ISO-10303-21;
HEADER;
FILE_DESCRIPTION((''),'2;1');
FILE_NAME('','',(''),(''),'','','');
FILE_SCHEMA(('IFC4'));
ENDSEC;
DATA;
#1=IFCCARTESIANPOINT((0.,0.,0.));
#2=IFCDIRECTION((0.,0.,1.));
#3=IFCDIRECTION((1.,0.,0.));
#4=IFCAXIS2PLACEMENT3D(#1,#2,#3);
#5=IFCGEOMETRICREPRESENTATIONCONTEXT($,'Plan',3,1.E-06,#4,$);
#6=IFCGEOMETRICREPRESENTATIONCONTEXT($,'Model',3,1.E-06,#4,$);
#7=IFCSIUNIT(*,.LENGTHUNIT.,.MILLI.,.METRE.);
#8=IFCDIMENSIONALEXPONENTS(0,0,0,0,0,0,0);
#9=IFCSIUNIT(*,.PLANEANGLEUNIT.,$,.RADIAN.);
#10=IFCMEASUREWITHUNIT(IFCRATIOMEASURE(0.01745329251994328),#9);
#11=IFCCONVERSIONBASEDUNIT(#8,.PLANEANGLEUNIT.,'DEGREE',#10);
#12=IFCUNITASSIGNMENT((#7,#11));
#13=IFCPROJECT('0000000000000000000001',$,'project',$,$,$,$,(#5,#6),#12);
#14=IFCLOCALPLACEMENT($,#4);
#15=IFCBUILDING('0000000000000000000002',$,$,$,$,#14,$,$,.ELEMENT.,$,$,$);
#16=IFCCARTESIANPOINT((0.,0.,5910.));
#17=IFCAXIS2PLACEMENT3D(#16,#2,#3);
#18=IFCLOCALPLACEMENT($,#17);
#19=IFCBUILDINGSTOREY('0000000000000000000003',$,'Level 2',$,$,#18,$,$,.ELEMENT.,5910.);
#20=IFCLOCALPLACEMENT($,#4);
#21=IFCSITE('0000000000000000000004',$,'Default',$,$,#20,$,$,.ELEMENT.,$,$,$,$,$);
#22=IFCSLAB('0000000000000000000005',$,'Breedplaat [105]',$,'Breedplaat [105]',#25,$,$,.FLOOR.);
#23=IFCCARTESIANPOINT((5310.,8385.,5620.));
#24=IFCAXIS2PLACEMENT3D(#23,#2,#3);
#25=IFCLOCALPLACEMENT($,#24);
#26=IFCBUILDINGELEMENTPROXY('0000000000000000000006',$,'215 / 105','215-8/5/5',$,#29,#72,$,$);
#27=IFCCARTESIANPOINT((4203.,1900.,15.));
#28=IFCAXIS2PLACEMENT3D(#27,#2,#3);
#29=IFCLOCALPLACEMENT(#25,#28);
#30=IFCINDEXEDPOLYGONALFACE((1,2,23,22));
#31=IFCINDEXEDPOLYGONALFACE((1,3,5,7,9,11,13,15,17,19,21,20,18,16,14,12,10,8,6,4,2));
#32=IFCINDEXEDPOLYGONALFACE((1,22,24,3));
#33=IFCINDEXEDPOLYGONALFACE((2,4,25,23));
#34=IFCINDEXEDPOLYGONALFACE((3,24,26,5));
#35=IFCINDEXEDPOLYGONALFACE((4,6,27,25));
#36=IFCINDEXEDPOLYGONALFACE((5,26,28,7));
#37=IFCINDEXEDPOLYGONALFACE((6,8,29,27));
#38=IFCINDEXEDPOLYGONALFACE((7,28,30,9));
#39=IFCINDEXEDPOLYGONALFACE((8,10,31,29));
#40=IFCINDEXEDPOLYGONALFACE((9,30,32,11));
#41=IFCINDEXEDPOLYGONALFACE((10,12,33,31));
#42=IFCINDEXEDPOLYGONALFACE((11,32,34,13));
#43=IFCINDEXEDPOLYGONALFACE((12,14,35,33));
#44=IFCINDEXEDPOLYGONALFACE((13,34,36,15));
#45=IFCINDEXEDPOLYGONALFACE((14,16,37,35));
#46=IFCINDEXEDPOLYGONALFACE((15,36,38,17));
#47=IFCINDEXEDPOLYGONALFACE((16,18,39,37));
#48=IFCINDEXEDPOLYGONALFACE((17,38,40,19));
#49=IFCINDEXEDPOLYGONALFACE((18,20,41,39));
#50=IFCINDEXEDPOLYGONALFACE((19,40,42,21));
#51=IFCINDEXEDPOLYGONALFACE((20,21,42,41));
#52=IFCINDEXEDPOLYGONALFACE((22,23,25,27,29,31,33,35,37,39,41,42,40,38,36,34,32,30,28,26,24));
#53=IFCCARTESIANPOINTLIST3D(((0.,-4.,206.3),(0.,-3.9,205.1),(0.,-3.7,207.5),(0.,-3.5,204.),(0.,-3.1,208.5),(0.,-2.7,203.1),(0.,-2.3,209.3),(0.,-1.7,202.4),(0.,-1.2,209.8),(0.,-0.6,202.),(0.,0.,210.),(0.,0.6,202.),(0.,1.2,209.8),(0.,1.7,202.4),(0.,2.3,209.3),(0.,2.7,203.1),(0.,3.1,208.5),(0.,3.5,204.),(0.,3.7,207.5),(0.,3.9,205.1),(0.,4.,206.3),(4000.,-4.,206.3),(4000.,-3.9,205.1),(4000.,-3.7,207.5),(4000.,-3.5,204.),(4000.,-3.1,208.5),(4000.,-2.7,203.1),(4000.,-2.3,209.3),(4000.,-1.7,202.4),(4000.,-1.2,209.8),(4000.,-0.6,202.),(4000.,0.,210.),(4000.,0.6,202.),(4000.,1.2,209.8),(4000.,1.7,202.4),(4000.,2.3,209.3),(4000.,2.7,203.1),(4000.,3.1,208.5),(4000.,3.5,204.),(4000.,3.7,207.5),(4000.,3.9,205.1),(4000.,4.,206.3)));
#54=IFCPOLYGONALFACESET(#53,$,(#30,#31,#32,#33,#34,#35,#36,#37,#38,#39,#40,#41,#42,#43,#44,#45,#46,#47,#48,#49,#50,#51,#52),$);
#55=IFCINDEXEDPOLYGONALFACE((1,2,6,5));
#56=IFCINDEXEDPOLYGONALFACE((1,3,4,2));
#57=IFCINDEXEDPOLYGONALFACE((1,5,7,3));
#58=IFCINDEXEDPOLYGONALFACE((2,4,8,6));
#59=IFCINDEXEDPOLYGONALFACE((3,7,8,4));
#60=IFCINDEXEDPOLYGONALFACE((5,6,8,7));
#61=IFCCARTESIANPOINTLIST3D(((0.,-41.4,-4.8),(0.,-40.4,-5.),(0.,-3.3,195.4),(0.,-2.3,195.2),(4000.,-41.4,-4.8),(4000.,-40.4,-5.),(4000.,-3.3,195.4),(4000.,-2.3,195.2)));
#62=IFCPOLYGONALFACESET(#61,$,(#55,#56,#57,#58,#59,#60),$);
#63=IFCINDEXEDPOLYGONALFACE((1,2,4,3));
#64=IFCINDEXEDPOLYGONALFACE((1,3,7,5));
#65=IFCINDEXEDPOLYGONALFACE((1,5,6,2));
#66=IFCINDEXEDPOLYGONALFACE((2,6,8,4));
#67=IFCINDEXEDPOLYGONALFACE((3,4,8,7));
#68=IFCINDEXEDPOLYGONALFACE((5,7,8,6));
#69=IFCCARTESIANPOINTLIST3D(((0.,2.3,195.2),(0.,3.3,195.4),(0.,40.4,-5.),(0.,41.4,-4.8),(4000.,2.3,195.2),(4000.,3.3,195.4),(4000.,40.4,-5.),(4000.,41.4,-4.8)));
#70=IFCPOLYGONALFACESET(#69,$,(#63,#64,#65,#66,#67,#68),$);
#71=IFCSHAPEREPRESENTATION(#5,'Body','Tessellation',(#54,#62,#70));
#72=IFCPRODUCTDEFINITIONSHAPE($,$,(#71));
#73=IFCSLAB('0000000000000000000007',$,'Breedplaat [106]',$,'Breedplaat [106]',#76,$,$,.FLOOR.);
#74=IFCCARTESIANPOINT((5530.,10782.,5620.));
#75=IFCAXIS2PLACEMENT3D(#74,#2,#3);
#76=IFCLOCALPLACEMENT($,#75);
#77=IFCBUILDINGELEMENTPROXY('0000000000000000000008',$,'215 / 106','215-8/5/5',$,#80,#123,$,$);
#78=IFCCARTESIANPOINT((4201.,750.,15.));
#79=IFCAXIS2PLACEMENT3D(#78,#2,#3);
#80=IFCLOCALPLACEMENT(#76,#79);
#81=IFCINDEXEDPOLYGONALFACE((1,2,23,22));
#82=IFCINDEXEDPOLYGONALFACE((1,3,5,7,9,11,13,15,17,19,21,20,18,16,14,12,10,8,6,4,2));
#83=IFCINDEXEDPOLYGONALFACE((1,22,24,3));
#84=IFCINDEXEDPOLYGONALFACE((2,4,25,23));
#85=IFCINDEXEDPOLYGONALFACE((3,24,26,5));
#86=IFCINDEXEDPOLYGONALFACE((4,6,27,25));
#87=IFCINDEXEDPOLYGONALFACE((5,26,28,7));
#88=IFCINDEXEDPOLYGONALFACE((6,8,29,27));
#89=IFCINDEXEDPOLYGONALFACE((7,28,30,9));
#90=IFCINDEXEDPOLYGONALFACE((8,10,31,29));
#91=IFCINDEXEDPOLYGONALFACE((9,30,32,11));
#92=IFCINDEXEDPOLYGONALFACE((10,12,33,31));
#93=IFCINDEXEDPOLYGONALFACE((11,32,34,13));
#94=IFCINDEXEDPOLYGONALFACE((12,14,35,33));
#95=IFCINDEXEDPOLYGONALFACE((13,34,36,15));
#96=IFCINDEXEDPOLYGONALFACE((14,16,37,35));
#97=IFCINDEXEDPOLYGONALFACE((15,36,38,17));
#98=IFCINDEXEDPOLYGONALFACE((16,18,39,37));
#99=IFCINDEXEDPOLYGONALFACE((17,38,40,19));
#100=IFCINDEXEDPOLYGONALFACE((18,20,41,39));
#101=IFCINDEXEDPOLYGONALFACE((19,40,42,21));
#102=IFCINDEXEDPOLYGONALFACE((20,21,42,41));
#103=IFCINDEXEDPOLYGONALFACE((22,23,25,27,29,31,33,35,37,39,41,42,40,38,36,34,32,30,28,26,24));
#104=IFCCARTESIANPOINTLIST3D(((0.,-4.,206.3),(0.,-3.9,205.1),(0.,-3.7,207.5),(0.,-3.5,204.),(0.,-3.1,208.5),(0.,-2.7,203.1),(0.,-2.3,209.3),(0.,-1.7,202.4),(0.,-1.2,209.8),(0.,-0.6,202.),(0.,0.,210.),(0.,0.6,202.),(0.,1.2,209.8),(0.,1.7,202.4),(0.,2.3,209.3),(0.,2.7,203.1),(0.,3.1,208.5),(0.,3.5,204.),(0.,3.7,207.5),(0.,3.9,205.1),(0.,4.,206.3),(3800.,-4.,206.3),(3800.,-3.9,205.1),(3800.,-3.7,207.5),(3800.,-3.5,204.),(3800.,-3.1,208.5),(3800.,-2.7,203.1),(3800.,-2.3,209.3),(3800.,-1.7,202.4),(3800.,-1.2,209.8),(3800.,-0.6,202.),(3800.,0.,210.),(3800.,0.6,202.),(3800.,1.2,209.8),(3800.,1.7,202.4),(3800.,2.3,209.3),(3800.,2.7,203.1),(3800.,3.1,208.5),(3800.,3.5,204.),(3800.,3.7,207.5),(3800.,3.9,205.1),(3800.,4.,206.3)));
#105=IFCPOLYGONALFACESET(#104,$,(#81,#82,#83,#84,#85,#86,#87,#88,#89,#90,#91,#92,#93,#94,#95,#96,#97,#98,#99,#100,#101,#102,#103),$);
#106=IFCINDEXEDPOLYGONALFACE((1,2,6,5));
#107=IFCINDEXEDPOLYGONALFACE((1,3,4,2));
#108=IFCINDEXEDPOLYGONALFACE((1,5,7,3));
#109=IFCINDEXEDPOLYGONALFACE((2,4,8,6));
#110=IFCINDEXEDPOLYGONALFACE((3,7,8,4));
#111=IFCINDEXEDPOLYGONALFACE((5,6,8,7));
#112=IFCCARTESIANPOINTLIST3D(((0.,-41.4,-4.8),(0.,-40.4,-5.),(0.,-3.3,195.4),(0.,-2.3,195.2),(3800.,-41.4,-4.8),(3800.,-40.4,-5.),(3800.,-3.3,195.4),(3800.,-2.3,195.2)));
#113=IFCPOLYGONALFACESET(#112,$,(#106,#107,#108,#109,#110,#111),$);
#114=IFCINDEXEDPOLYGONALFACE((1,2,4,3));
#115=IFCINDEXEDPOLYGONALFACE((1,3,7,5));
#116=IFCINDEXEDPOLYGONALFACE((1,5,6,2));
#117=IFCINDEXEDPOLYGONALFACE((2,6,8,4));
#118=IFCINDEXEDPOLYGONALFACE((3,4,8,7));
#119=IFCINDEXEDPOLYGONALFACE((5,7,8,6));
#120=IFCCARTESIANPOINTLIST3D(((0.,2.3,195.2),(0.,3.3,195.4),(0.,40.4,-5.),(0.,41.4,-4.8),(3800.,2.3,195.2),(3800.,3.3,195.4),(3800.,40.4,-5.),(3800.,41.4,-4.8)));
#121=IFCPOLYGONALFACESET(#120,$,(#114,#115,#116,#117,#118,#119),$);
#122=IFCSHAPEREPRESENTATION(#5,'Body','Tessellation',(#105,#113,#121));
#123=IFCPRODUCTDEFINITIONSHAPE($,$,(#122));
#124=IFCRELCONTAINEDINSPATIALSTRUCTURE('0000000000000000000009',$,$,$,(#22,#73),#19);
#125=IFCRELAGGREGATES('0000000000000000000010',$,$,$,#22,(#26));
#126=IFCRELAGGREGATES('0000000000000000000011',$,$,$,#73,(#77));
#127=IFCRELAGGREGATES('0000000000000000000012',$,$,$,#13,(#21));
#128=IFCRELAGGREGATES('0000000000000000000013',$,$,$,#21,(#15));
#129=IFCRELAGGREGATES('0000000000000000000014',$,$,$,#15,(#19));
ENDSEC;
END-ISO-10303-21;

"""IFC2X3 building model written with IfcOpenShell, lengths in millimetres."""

from ifc_helpers import new_model, entity, si_unit, converted_unit, frame, origin_with_axes, origin_2d_with_axis, place, context, project, spatial, rectangle, circle, extrude, element, aggregate, save


model = new_model("IFC2X3")

# Units and contexts
plan_context = context("Plan", 3, precision=1e-06, world=origin_with_axes())
model_context = context("Model", 3, precision=1e-06, world=origin_with_axes())
ifc_project = project(units=[si_unit("LENGTHUNIT", "METRE", prefix="MILLI"), converted_unit("PLANEANGLEUNIT", "DEGREE", entity("IfcRatioMeasure", 0.01745329251994328), si_unit("PLANEANGLEUNIT", "RADIAN"), dimensions=[0, 0, 0, 0, 0, 0, 0])], contexts=[plan_context, model_context])

# Site, building, storey
site_placement = place(None, origin_with_axes())
site = spatial("IfcSite", under=ifc_project, at=site_placement, Name="Default", CompositionType="ELEMENT")
building_placement = place(None, origin_with_axes())
building = spatial("IfcBuilding", under=site, at=building_placement, CompositionType="ELEMENT")
storey_placement = place(None, frame((0.0, 0.0, 5910.0), z_axis=(0.0, 0.0, 1.0), x_axis=(1.0, 0.0, 0.0)))
storey = spatial("IfcBuildingStorey", under=building, at=storey_placement, Name="Level 2", CompositionType="ELEMENT", Elevation=5910.0)

# Slabs, building element proxies
slab_1_placement = place(None, frame((5310.0, 8385.0, 5620.0), z_axis=(0.0, 0.0, 1.0), x_axis=(1.0, 0.0, 0.0)))
slab_1 = element("IfcSlab", 1, at=slab_1_placement, inside=storey, Name="Breedplaat [105]", ObjectType="Breedplaat [105]", PredefinedType="FLOOR")
proxy_1_placement = place(slab_1_placement, frame((4203.0, 1900.0, 15.0), z_axis=(0.0, 0.0, 1.0), x_axis=(1.0, 0.0, 0.0)))
proxy_1 = element("IfcBuildingElementProxy", 2, at=proxy_1_placement, Name="215 / 105", Description="215-8/5/5", context=plan_context, shape_type="SweptSolid", body=[
    extrude(circle(Radius=4.0, at=origin_2d_with_axis()), frame((0.0, 0.0, 206.0), z_axis=(1.0, 0.0, 0.0), x_axis=(0.0, 0.0, 1.0)), (0.0, 0.0, 1.0), 4000.0),
    extrude(rectangle(XDim=203.8, YDim=1.0, at=origin_2d_with_axis()), frame((0.0, -21.9, 95.2), z_axis=(1.0, 0.0, 0.0), x_axis=(0.0, 0.187112, 0.982339)), (0.0, 0.0, 1.0), 4000.0),
    extrude(rectangle(XDim=203.8, YDim=1.0, at=origin_2d_with_axis()), frame((0.0, 21.9, 95.2), z_axis=(1.0, 0.0, 0.0), x_axis=(0.0, -0.187112, 0.982339)), (0.0, 0.0, 1.0), 4000.0),
])
aggregate(slab_1, [proxy_1])
slab_2_placement = place(None, frame((5530.0, 10782.0, 5620.0), z_axis=(0.0, 0.0, 1.0), x_axis=(1.0, 0.0, 0.0)))
slab_2 = element("IfcSlab", 3, at=slab_2_placement, inside=storey, Name="Breedplaat [106]", ObjectType="Breedplaat [106]", PredefinedType="FLOOR")
proxy_2_placement = place(slab_2_placement, frame((4201.0, 750.0, 15.0), z_axis=(0.0, 0.0, 1.0), x_axis=(1.0, 0.0, 0.0)))
proxy_2 = element("IfcBuildingElementProxy", 4, at=proxy_2_placement, Name="215 / 106", Description="215-8/5/5", context=plan_context, shape_type="SweptSolid", body=[
    extrude(circle(Radius=4.0, at=origin_2d_with_axis()), frame((0.0, 0.0, 206.0), z_axis=(1.0, 0.0, 0.0), x_axis=(0.0, 0.0, 1.0)), (0.0, 0.0, 1.0), 3800.0),
    extrude(rectangle(XDim=203.8, YDim=1.0, at=origin_2d_with_axis()), frame((0.0, -21.9, 95.2), z_axis=(1.0, 0.0, 0.0), x_axis=(0.0, 0.187112, 0.982339)), (0.0, 0.0, 1.0), 3800.0),
    extrude(rectangle(XDim=203.8, YDim=1.0, at=origin_2d_with_axis()), frame((0.0, 21.9, 95.2), z_axis=(1.0, 0.0, 0.0), x_axis=(0.0, -0.187112, 0.982339)), (0.0, 0.0, 1.0), 3800.0),
])
aggregate(slab_2, [proxy_2])

save(model, "model.ifc")
